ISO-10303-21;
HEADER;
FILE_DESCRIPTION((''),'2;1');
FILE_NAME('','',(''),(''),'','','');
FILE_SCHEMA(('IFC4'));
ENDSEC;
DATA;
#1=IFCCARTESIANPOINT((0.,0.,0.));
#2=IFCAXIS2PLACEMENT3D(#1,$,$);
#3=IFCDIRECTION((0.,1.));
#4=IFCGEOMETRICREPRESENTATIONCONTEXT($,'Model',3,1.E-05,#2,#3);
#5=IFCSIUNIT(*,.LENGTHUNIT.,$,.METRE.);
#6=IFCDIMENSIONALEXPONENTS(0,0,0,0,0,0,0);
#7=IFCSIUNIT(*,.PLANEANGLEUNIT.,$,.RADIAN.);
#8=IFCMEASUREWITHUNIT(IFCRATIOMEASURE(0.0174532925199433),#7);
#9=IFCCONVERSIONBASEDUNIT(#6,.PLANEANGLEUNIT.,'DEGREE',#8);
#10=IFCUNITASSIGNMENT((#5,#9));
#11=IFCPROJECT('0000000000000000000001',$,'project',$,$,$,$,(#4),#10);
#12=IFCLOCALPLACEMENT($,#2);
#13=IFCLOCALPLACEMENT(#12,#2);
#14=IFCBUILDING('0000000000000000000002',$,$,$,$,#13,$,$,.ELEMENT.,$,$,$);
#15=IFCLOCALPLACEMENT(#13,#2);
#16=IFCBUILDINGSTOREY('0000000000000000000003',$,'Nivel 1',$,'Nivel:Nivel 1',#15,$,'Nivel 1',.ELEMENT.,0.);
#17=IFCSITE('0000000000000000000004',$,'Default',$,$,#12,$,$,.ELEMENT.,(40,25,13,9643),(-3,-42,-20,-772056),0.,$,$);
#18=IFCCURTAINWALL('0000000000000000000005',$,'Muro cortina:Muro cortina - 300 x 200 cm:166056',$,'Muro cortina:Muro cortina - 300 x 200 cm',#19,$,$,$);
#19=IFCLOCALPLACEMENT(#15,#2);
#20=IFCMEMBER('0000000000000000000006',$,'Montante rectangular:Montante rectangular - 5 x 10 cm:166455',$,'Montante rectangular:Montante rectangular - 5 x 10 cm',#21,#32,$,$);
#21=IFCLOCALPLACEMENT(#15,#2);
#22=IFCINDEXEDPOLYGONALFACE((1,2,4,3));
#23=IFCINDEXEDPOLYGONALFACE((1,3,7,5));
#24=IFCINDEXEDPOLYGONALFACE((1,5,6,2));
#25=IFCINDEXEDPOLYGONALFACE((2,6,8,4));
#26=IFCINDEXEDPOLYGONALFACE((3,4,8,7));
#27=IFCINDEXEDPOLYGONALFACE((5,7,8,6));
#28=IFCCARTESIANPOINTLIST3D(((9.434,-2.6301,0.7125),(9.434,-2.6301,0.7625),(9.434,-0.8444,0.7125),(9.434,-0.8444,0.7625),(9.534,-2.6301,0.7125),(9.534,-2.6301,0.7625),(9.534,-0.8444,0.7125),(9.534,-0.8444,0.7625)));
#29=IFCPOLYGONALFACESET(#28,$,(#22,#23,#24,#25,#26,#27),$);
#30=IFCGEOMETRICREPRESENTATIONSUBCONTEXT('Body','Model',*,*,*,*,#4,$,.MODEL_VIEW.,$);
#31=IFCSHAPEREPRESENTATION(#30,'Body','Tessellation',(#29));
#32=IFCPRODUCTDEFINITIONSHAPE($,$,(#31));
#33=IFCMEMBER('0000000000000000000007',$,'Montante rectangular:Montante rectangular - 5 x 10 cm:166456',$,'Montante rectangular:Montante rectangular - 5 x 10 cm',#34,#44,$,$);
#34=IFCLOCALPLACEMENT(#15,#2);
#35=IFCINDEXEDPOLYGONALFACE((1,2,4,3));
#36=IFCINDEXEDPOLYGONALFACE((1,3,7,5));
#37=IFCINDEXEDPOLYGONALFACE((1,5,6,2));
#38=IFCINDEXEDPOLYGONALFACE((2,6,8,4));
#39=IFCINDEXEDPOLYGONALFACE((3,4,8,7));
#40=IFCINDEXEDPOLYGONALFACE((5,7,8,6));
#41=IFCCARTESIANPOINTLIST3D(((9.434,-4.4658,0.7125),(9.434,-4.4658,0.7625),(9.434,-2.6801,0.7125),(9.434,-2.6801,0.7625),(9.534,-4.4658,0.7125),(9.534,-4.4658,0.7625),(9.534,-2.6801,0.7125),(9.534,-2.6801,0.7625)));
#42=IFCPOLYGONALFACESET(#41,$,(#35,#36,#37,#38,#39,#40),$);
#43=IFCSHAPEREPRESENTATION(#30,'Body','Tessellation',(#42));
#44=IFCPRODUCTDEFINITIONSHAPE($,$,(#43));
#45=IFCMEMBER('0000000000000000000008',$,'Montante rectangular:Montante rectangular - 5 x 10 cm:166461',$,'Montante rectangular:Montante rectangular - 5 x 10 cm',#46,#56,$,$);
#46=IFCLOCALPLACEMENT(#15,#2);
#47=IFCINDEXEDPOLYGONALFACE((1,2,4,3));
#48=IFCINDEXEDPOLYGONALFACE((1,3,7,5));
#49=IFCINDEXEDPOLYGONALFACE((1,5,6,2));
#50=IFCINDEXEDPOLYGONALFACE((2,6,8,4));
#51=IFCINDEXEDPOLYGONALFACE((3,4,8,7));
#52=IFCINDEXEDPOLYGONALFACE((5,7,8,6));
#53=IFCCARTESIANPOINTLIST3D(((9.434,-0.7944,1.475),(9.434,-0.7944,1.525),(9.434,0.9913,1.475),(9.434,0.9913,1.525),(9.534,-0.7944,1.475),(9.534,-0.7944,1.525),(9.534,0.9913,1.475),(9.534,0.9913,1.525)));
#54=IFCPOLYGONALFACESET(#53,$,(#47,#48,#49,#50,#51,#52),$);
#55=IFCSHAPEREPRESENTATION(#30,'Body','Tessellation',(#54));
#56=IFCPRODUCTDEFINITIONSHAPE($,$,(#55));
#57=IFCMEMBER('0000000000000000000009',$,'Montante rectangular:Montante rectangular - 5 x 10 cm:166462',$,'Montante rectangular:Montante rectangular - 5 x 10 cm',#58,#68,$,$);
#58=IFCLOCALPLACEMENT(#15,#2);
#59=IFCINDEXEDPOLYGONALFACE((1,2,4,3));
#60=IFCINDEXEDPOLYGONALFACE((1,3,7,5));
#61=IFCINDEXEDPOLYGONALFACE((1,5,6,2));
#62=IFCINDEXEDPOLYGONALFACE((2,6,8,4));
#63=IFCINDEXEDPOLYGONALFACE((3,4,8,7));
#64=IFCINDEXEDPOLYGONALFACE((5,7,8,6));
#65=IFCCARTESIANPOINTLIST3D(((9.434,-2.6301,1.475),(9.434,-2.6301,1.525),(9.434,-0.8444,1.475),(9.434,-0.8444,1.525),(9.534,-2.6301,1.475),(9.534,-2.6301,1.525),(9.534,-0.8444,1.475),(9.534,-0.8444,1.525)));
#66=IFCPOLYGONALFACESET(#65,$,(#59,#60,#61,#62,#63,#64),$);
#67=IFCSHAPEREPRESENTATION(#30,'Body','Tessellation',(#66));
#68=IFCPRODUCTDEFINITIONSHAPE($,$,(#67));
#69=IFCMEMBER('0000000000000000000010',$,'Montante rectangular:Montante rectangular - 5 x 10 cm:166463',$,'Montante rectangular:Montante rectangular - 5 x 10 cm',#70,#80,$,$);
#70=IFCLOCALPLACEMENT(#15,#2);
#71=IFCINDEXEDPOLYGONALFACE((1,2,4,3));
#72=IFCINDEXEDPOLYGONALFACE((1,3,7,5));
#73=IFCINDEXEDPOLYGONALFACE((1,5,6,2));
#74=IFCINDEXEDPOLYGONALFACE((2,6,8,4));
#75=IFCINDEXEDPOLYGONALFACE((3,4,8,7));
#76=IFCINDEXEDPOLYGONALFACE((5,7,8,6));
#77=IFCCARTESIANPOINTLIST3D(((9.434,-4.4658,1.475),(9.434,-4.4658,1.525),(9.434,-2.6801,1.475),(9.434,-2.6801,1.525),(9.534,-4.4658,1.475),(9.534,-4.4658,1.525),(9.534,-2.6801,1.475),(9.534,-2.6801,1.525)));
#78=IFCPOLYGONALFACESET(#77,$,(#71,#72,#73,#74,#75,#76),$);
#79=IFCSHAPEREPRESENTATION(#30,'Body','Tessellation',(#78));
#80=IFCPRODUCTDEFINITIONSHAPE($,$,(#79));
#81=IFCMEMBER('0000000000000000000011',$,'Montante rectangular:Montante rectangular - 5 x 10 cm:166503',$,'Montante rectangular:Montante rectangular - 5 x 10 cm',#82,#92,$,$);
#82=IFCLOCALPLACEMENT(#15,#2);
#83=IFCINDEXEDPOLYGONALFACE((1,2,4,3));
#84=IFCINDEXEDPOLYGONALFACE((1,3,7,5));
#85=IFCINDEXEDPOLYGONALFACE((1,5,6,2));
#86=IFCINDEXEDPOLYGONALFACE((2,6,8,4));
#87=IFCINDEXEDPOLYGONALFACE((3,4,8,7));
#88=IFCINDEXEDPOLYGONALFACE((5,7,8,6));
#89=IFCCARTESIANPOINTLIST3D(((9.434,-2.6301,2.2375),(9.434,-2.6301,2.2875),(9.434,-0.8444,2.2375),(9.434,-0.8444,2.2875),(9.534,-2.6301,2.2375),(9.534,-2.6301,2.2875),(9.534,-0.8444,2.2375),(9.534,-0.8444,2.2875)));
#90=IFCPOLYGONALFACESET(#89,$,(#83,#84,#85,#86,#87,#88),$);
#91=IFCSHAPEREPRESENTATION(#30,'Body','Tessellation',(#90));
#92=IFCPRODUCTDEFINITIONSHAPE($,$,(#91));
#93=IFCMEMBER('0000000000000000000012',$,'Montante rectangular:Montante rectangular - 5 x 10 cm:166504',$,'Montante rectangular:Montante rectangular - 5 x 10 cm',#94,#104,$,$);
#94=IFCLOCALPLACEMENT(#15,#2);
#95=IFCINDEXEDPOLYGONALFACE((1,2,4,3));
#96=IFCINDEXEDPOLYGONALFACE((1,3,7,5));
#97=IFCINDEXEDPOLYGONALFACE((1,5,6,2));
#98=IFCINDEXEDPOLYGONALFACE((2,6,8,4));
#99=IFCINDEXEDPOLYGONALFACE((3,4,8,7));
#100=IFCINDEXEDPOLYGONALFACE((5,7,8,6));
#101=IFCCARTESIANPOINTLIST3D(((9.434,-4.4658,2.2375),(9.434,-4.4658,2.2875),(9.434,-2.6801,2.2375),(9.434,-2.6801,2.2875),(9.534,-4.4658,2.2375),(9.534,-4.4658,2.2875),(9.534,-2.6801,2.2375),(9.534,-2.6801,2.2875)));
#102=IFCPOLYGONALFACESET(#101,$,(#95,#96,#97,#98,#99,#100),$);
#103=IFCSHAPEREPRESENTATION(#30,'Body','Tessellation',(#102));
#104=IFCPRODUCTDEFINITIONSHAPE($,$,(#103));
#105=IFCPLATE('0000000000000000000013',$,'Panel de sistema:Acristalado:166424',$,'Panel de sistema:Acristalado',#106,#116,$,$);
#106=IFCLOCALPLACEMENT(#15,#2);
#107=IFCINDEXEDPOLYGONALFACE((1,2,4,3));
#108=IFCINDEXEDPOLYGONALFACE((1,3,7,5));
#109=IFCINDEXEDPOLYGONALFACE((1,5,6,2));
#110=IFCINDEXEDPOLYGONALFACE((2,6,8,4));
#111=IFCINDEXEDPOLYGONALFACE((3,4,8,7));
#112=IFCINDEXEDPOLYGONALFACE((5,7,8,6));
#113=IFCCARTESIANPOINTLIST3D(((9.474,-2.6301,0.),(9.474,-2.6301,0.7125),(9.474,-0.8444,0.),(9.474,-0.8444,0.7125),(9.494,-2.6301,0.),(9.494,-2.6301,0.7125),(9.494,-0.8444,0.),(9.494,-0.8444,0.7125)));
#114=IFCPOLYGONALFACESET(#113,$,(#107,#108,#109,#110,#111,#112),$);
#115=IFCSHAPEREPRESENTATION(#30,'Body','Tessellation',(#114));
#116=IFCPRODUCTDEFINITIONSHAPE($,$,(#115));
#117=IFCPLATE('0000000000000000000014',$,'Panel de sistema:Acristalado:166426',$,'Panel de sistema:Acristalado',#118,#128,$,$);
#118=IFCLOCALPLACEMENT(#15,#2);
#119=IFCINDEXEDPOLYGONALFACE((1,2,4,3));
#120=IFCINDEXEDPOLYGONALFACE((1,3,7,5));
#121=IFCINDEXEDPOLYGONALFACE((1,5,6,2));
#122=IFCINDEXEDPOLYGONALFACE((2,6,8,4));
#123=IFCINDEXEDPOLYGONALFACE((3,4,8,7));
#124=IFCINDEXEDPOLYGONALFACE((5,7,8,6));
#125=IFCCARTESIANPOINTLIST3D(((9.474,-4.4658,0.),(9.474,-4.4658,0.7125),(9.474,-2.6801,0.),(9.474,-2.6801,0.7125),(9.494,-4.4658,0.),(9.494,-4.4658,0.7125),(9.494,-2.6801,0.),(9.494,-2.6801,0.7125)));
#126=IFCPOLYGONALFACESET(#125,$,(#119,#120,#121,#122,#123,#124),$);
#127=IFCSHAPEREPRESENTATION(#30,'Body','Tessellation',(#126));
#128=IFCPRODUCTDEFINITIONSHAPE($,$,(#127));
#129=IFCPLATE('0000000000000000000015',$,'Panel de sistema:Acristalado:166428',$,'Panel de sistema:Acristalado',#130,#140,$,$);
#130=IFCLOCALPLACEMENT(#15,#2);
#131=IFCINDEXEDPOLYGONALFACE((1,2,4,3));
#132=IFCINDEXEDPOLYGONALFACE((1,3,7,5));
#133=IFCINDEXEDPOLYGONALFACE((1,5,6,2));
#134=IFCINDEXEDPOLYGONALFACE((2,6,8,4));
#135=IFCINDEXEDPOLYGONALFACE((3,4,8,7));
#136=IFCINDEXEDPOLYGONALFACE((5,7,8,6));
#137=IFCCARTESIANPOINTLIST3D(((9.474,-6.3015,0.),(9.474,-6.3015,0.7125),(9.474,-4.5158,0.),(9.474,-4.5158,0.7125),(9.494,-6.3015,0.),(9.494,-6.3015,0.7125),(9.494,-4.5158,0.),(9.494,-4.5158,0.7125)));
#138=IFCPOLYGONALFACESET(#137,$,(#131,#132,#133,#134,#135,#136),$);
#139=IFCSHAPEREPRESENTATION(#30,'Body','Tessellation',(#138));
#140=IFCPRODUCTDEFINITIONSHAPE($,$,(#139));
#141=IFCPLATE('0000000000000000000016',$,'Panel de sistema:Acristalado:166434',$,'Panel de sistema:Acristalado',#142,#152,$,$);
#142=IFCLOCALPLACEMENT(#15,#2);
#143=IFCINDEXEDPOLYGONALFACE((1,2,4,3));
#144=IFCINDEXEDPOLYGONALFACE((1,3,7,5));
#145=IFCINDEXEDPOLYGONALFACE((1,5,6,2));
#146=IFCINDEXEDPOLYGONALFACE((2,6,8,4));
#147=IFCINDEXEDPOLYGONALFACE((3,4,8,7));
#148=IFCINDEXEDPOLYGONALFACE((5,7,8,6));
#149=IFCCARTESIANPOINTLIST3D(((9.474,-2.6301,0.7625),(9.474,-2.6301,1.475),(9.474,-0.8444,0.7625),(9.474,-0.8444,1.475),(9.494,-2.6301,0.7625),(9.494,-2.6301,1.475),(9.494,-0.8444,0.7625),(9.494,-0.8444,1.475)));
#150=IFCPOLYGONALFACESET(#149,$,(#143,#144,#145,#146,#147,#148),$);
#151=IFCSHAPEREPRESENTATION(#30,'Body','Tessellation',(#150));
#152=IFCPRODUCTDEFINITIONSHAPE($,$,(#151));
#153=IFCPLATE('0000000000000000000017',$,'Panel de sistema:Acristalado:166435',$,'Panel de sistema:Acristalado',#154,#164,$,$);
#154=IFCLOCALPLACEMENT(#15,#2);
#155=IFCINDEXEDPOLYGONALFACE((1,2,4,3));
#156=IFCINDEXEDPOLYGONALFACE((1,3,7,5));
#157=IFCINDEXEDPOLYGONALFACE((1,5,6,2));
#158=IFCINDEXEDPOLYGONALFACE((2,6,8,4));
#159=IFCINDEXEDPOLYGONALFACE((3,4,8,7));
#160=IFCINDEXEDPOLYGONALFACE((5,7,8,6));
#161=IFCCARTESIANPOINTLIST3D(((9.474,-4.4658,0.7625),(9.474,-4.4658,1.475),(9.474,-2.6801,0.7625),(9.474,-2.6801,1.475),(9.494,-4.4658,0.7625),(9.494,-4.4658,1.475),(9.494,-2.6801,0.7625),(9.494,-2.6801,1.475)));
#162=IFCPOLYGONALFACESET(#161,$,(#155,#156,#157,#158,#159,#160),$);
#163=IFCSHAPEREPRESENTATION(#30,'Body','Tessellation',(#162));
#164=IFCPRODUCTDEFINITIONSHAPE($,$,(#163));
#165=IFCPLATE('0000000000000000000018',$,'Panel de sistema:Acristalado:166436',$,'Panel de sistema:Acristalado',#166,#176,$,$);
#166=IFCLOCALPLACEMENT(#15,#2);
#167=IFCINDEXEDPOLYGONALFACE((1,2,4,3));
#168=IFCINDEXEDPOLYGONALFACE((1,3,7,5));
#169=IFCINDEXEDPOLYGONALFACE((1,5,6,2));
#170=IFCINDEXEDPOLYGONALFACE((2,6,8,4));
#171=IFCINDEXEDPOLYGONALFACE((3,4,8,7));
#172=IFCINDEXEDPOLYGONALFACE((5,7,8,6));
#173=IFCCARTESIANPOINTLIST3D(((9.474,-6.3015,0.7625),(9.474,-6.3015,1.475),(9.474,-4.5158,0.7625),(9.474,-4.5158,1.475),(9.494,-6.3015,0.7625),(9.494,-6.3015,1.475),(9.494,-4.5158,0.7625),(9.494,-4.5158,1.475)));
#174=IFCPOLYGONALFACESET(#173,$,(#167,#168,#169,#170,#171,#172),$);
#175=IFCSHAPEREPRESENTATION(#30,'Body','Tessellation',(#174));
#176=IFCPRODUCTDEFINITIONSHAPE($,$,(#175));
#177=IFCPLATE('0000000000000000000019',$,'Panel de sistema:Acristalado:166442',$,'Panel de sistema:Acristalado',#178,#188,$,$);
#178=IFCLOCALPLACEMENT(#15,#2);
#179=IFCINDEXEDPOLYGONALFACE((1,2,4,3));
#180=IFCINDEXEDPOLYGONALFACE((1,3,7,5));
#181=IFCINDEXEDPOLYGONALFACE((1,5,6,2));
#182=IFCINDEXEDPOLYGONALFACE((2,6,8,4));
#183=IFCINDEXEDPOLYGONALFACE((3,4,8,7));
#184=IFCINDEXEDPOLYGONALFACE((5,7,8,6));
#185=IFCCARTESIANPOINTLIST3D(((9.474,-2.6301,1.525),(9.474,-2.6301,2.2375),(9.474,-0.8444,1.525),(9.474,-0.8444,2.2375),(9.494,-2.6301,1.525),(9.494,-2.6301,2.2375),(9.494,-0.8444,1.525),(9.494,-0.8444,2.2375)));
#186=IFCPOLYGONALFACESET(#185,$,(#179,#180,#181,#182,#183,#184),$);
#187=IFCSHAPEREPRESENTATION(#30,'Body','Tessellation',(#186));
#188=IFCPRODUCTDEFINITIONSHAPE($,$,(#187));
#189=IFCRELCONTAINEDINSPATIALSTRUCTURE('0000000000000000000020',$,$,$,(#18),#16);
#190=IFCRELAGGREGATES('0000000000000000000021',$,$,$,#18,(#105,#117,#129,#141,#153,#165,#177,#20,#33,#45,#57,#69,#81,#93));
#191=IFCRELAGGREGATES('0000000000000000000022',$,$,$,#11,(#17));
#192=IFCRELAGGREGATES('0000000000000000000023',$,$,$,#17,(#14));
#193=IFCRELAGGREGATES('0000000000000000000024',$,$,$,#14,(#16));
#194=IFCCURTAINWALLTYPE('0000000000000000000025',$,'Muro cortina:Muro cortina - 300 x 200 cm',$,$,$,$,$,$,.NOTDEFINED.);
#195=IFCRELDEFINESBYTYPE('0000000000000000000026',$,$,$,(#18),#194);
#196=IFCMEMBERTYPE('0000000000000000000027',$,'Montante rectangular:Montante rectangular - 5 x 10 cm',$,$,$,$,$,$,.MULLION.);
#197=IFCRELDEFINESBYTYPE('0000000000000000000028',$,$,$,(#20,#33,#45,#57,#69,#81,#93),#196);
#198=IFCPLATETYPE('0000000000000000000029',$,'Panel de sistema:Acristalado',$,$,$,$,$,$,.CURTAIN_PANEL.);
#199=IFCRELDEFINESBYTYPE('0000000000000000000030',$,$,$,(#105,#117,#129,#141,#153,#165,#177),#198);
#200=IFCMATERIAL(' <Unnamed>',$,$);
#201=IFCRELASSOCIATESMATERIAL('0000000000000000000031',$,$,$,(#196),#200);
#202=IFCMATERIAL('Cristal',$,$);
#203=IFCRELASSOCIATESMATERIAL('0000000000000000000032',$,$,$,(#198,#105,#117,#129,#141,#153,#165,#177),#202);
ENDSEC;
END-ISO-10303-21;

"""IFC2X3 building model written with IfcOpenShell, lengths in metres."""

from ifc_helpers import new_model, entity, si_unit, converted_unit, direction, frame, origin, origin_2d_with_axis, place, context, subcontext, project, spatial, rectangle, extrude, source, transform, mapped, material, type_object, type_shapes, element, aggregate, save


model = new_model("IFC2X3")

# Units and contexts
model_context = context("Model", 3, precision=1e-05, world=origin(), true_north=direction((0.0, 1.0)))
body_context = subcontext(model_context, "Body", "Model", "MODEL_VIEW")
ifc_project = project(units=[si_unit("LENGTHUNIT", "METRE"), converted_unit("PLANEANGLEUNIT", "DEGREE", entity("IfcRatioMeasure", 0.0174532925199433), si_unit("PLANEANGLEUNIT", "RADIAN"), dimensions=[0, 0, 0, 0, 0, 0, 0])], contexts=[model_context])

# Site, building, storey
site_placement = place(None, origin())
site = spatial("IfcSite", under=ifc_project, at=site_placement, Name="Default", CompositionType="ELEMENT", RefLatitude=(40, 25, 13, 9643), RefLongitude=(-3, -42, -20, -772056), RefElevation=0.0)
building_placement = place(site_placement, origin())
building = spatial("IfcBuilding", under=site, at=building_placement, CompositionType="ELEMENT")
storey_placement = place(building_placement, origin())
storey = spatial("IfcBuildingStorey", under=building, at=storey_placement, Name="Nivel 1", ObjectType="Nivel:Nivel 1", LongName="Nivel 1", CompositionType="ELEMENT", Elevation=0.0)

# Curtain wall, members, plates
curtain_wall_type = type_object("IfcCurtainWallType", Name="Muro cortina:Muro cortina - 300 x 200 cm", PredefinedType="NOTDEFINED")
curtain_wall_placement = place(storey_placement, origin())
curtain_wall = element("IfcCurtainWall", 1, at=curtain_wall_placement, inside=storey, type_object=curtain_wall_type, Name="Muro cortina:Muro cortina - 300 x 200 cm:166056", ObjectType="Muro cortina:Muro cortina - 300 x 200 cm")
ifc_material_1 = material(Name=" <Unnamed>")
member_type_1 = type_object("IfcMemberType", Name="Montante rectangular:Montante rectangular - 5 x 10 cm", PredefinedType="MULLION", material=ifc_material_1)
shared_shape_1 = source(origin(), body_context, "Body", "SweptSolid", [
    extrude(rectangle(XDim=0.1, YDim=0.05, at=origin_2d_with_axis()), frame((0.0, 0.0, -1.7857), z_axis=(0.0, 0.0, 1.0), x_axis=(0.0, -1.0, 0.0)), (0.0, 0.0, 1.0), 1.7857),
])
type_shapes(member_type_1, [shared_shape_1])
member_1_placement = place(storey_placement, frame((9.484, -2.6301, 0.7375), z_axis=(0.0, -1.0, 0.0), x_axis=(0.0, 0.0, 1.0)))
member_1 = element("IfcMember", 2, at=member_1_placement, type_object=member_type_1, Name="Montante rectangular:Montante rectangular - 5 x 10 cm:166455", ObjectType="Montante rectangular:Montante rectangular - 5 x 10 cm", context=body_context, shape_type="MappedRepresentation", body=[
    mapped(shared_shape_1, transform((0.0, 0.0, 0.0), scale=1.0)),
])
member_2_placement = place(storey_placement, frame((9.484, -4.4658, 0.7375), z_axis=(0.0, -1.0, 0.0), x_axis=(0.0, 0.0, 1.0)))
member_2 = element("IfcMember", 3, at=member_2_placement, type_object=member_type_1, Name="Montante rectangular:Montante rectangular - 5 x 10 cm:166456", ObjectType="Montante rectangular:Montante rectangular - 5 x 10 cm", context=body_context, shape_type="MappedRepresentation", body=[
    mapped(shared_shape_1, transform((0.0, 0.0, 0.0), scale=1.0)),
])
member_3_placement = place(storey_placement, frame((9.484, -0.7944, 1.5), z_axis=(0.0, -1.0, 0.0), x_axis=(0.0, 0.0, 1.0)))
member_3 = element("IfcMember", 4, at=member_3_placement, type_object=member_type_1, Name="Montante rectangular:Montante rectangular - 5 x 10 cm:166461", ObjectType="Montante rectangular:Montante rectangular - 5 x 10 cm", context=body_context, shape_type="MappedRepresentation", body=[
    mapped(shared_shape_1, transform((0.0, 0.0, 0.0), scale=1.0)),
])
member_4_placement = place(storey_placement, frame((9.484, -2.6301, 1.5), z_axis=(0.0, -1.0, 0.0), x_axis=(0.0, 0.0, 1.0)))
member_4 = element("IfcMember", 5, at=member_4_placement, type_object=member_type_1, Name="Montante rectangular:Montante rectangular - 5 x 10 cm:166462", ObjectType="Montante rectangular:Montante rectangular - 5 x 10 cm", context=body_context, shape_type="MappedRepresentation", body=[
    mapped(shared_shape_1, transform((0.0, 0.0, 0.0), scale=1.0)),
])
member_5_placement = place(storey_placement, frame((9.484, -4.4658, 1.5), z_axis=(0.0, -1.0, 0.0), x_axis=(0.0, 0.0, 1.0)))
member_5 = element("IfcMember", 6, at=member_5_placement, type_object=member_type_1, Name="Montante rectangular:Montante rectangular - 5 x 10 cm:166463", ObjectType="Montante rectangular:Montante rectangular - 5 x 10 cm", context=body_context, shape_type="MappedRepresentation", body=[
    mapped(shared_shape_1, transform((0.0, 0.0, 0.0), scale=1.0)),
])
member_6_placement = place(storey_placement, frame((9.484, -2.6301, 2.2625), z_axis=(0.0, -1.0, 0.0), x_axis=(0.0, 0.0, 1.0)))
member_6 = element("IfcMember", 7, at=member_6_placement, type_object=member_type_1, Name="Montante rectangular:Montante rectangular - 5 x 10 cm:166503", ObjectType="Montante rectangular:Montante rectangular - 5 x 10 cm", context=body_context, shape_type="MappedRepresentation", body=[
    mapped(shared_shape_1, transform((0.0, 0.0, 0.0), scale=1.0)),
])
member_7_placement = place(storey_placement, frame((9.484, -4.4658, 2.2625), z_axis=(0.0, -1.0, 0.0), x_axis=(0.0, 0.0, 1.0)))
member_7 = element("IfcMember", 8, at=member_7_placement, type_object=member_type_1, Name="Montante rectangular:Montante rectangular - 5 x 10 cm:166504", ObjectType="Montante rectangular:Montante rectangular - 5 x 10 cm", context=body_context, shape_type="MappedRepresentation", body=[
    mapped(shared_shape_1, transform((0.0, 0.0, 0.0), scale=1.0)),
])
ifc_material_2 = material(Name="Cristal")
plate_type = type_object("IfcPlateType", Name="Panel de sistema:Acristalado", PredefinedType="CURTAIN_PANEL", material=ifc_material_2)
shared_shape_2 = source(origin(), body_context, "Body", "SweptSolid", [
    extrude(rectangle(XDim=0.02, YDim=1.7857, at=origin_2d_with_axis()), frame((0.0, 0.0, 0.0), z_axis=(0.0, 0.0, 1.0), x_axis=(0.0, 1.0, 0.0)), (0.0, 0.0, 1.0), 0.7125),
])
type_shapes(plate_type, [shared_shape_2])
plate_1_placement = place(curtain_wall_placement, frame((9.484, -1.7373, 0.0), z_axis=(0.0, 0.0, 1.0), x_axis=(0.0, -1.0, 0.0)))
plate_1 = element("IfcPlate", 9, at=plate_1_placement, type_object=plate_type, material=ifc_material_2, Name="Panel de sistema:Acristalado:166424", ObjectType="Panel de sistema:Acristalado", context=body_context, shape_type="MappedRepresentation", body=[
    mapped(shared_shape_2, transform((0.0, 0.0, 0.0), scale=1.0)),
])
plate_2_placement = place(curtain_wall_placement, frame((9.484, -3.573, 0.0), z_axis=(0.0, 0.0, 1.0), x_axis=(0.0, -1.0, 0.0)))
plate_2 = element("IfcPlate", 10, at=plate_2_placement, type_object=plate_type, material=ifc_material_2, Name="Panel de sistema:Acristalado:166426", ObjectType="Panel de sistema:Acristalado", context=body_context, shape_type="MappedRepresentation", body=[
    mapped(shared_shape_2, transform((0.0, 0.0, 0.0), scale=1.0)),
])
plate_3_placement = place(curtain_wall_placement, frame((9.484, -5.4087, 0.0), z_axis=(0.0, 0.0, 1.0), x_axis=(0.0, -1.0, 0.0)))
plate_3 = element("IfcPlate", 11, at=plate_3_placement, type_object=plate_type, material=ifc_material_2, Name="Panel de sistema:Acristalado:166428", ObjectType="Panel de sistema:Acristalado", context=body_context, shape_type="MappedRepresentation", body=[
    mapped(shared_shape_2, transform((0.0, 0.0, 0.0), scale=1.0)),
])
plate_4_placement = place(curtain_wall_placement, frame((9.484, -1.7373, 0.7625), z_axis=(0.0, 0.0, 1.0), x_axis=(0.0, -1.0, 0.0)))
plate_4 = element("IfcPlate", 12, at=plate_4_placement, type_object=plate_type, material=ifc_material_2, Name="Panel de sistema:Acristalado:166434", ObjectType="Panel de sistema:Acristalado", context=body_context, shape_type="MappedRepresentation", body=[
    mapped(shared_shape_2, transform((0.0, 0.0, 0.0), scale=1.0)),
])
plate_5_placement = place(curtain_wall_placement, frame((9.484, -3.573, 0.7625), z_axis=(0.0, 0.0, 1.0), x_axis=(0.0, -1.0, 0.0)))
plate_5 = element("IfcPlate", 13, at=plate_5_placement, type_object=plate_type, material=ifc_material_2, Name="Panel de sistema:Acristalado:166435", ObjectType="Panel de sistema:Acristalado", context=body_context, shape_type="MappedRepresentation", body=[
    mapped(shared_shape_2, transform((0.0, 0.0, 0.0), scale=1.0)),
])
plate_6_placement = place(curtain_wall_placement, frame((9.484, -5.4087, 0.7625), z_axis=(0.0, 0.0, 1.0), x_axis=(0.0, -1.0, 0.0)))
plate_6 = element("IfcPlate", 14, at=plate_6_placement, type_object=plate_type, material=ifc_material_2, Name="Panel de sistema:Acristalado:166436", ObjectType="Panel de sistema:Acristalado", context=body_context, shape_type="MappedRepresentation", body=[
    mapped(shared_shape_2, transform((0.0, 0.0, 0.0), scale=1.0)),
])
plate_7_placement = place(curtain_wall_placement, frame((9.484, -1.7373, 1.525), z_axis=(0.0, 0.0, 1.0), x_axis=(0.0, -1.0, 0.0)))
plate_7 = element("IfcPlate", 15, at=plate_7_placement, type_object=plate_type, material=ifc_material_2, Name="Panel de sistema:Acristalado:166442", ObjectType="Panel de sistema:Acristalado", context=body_context, shape_type="MappedRepresentation", body=[
    mapped(shared_shape_2, transform((0.0, 0.0, 0.0), scale=1.0)),
])
aggregate(curtain_wall, [plate_1, plate_2, plate_3, plate_4, plate_5, plate_6, plate_7, member_1, member_2, member_3, member_4, member_5, member_6, member_7])

save(model, "model.ifc")
